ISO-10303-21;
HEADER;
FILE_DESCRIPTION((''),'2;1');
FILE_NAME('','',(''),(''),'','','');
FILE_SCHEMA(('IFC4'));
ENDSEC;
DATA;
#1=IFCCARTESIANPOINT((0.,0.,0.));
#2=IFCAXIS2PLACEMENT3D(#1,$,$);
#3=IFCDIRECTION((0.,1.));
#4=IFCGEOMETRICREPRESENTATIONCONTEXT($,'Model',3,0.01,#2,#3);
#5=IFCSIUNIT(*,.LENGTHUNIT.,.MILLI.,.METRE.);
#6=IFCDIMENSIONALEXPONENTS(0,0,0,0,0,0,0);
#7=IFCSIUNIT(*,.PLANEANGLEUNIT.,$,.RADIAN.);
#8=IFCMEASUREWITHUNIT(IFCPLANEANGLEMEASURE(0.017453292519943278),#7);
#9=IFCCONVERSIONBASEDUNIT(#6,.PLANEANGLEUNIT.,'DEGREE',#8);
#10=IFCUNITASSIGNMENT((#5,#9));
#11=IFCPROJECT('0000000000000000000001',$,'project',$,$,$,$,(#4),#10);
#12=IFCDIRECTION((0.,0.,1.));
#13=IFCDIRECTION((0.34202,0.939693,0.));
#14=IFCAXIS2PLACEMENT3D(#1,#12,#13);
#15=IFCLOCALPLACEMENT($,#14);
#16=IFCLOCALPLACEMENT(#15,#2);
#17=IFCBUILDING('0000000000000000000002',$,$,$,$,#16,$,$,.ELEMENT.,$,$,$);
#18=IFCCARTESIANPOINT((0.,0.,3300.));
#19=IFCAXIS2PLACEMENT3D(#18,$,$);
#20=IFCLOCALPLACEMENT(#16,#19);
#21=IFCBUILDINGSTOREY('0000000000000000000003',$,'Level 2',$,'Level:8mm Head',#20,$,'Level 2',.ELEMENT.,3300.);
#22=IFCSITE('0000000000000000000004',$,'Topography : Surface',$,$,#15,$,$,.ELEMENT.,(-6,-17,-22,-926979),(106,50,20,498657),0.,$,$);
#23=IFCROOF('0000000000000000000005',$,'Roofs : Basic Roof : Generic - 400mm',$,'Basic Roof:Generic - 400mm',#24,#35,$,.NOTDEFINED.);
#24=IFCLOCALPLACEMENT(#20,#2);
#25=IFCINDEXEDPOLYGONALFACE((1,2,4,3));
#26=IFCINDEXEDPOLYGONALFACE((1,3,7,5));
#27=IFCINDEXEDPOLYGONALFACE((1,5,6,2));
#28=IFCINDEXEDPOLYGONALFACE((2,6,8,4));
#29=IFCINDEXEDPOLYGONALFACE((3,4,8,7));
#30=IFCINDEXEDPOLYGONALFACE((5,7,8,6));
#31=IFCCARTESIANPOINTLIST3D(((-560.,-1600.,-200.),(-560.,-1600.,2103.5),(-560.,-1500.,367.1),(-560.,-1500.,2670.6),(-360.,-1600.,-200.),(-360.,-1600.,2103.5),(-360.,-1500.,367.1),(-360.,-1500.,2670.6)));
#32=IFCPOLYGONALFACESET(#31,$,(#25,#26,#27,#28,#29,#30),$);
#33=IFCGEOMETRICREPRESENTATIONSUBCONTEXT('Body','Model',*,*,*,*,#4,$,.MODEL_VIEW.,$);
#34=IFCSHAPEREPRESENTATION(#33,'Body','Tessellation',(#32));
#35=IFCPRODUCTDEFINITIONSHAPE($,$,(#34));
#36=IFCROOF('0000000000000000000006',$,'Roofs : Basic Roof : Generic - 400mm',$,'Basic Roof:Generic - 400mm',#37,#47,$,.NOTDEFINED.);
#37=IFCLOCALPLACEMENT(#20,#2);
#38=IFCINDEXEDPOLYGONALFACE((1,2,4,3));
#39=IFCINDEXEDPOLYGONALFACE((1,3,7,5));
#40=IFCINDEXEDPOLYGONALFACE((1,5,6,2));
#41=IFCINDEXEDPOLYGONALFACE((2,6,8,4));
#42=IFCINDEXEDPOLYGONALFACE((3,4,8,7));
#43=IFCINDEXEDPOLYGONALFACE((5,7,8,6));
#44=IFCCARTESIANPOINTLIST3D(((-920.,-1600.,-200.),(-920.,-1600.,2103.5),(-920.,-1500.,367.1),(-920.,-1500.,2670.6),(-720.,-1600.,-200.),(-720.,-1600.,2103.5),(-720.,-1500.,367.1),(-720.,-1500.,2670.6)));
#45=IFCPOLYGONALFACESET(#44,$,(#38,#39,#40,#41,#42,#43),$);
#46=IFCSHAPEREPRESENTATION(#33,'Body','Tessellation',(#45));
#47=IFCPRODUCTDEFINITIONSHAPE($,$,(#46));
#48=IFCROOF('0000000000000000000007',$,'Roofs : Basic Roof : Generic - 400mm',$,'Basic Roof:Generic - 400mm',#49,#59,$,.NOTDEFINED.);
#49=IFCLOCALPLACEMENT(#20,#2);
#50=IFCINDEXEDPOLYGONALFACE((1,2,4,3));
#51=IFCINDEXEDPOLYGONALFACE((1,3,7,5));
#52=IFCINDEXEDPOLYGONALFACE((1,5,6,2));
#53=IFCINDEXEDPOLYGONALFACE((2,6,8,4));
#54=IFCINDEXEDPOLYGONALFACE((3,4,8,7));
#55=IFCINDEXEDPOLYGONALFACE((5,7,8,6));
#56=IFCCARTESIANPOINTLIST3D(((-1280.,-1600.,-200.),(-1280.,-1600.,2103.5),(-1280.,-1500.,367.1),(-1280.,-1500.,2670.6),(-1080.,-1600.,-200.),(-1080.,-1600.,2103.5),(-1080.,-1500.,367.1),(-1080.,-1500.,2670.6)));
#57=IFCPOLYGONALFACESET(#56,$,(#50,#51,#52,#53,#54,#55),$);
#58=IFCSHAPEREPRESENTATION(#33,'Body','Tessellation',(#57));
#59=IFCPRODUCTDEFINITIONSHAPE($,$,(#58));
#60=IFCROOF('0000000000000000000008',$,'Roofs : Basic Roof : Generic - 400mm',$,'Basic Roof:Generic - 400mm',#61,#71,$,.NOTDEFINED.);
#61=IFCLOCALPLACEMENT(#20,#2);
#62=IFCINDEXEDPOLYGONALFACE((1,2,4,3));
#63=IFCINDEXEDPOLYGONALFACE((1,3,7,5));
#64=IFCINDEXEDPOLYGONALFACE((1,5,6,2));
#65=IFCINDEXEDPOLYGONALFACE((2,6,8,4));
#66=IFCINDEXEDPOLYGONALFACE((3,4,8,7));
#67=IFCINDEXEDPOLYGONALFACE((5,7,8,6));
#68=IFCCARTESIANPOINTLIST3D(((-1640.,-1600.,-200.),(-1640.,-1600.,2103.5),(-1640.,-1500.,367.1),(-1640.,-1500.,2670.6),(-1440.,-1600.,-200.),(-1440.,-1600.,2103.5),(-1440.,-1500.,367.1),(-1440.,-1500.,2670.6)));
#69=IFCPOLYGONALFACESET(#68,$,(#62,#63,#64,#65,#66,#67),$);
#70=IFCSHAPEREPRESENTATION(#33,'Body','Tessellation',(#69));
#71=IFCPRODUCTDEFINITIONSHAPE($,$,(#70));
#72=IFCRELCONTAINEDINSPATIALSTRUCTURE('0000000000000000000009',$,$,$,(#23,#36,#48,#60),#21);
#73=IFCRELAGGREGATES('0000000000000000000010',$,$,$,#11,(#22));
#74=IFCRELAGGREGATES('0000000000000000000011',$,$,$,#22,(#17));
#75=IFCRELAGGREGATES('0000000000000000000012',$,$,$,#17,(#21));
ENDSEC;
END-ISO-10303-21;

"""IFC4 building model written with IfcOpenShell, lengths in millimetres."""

from ifc_helpers import new_model, entity, si_unit, converted_unit, direction, frame, origin, place, context, subcontext, project, spatial, indexed_curve, outline, extrude, element, save


model = new_model("IFC4")

# Units and contexts
model_context = context("Model", 3, precision=0.01, world=origin(), true_north=direction((0.0, 1.0)))
body_context = subcontext(model_context, "Body", "Model", "MODEL_VIEW")
ifc_project = project(units=[si_unit("LENGTHUNIT", "METRE", prefix="MILLI"), converted_unit("PLANEANGLEUNIT", "DEGREE", entity("IfcPlaneAngleMeasure", 0.017453292519943278), si_unit("PLANEANGLEUNIT", "RADIAN"), dimensions=[0, 0, 0, 0, 0, 0, 0])], contexts=[model_context])

# Site, building, storey
site_placement = place(None, frame((0.0, 0.0, 0.0), z_axis=(0.0, 0.0, 1.0), x_axis=(0.34202, 0.939693, 0.0)))
site = spatial("IfcSite", under=ifc_project, at=site_placement, Name="Topography : Surface", CompositionType="ELEMENT", RefLatitude=(-6, -17, -22, -926979), RefLongitude=(106, 50, 20, 498657), RefElevation=0.0)
building_placement = place(site_placement, origin())
building = spatial("IfcBuilding", under=site, at=building_placement, CompositionType="ELEMENT")
storey_placement = place(building_placement, frame((0.0, 0.0, 3300.0)))
storey = spatial("IfcBuildingStorey", under=building, at=storey_placement, Name="Level 2", ObjectType="Level:8mm Head", LongName="Level 2", CompositionType="ELEMENT", Elevation=3300.0)

# Roofs
for number, where, name in (
    (1, (-560.0, -1600.0, -200.0), "Roofs : Basic Roof : Generic - 400mm"),
    (2, (-920.0, -1600.0, -200.0), "Roofs : Basic Roof : Generic - 400mm"),
    (3, (-1280.0, -1600.0, -200.0), "Roofs : Basic Roof : Generic - 400mm"),
    (4, (-1640.0, -1600.0, -200.0), "Roofs : Basic Roof : Generic - 400mm"),
):
    element("IfcRoof", number, at=place(storey_placement, frame(where)), inside=storey, Name=name, ObjectType="Basic Roof:Generic - 400mm", PredefinedType="NOTDEFINED", context=body_context, shape_type="SweptSolid", body=[
        extrude(outline(indexed_curve([(100.0, 287.9), (-100.0, 287.9), (-100.0, -287.9), (100.0, -287.9), (100.0, 287.9)], self_intersect=False)), frame((100.0, 50.0, 283.6), z_axis=(0.0, -0.984808, 0.173648), x_axis=(1.0, 0.0, 0.0)), (0.0, 0.984808, 0.173648), 2303.5),
    ])

save(model, "model.ifc")
